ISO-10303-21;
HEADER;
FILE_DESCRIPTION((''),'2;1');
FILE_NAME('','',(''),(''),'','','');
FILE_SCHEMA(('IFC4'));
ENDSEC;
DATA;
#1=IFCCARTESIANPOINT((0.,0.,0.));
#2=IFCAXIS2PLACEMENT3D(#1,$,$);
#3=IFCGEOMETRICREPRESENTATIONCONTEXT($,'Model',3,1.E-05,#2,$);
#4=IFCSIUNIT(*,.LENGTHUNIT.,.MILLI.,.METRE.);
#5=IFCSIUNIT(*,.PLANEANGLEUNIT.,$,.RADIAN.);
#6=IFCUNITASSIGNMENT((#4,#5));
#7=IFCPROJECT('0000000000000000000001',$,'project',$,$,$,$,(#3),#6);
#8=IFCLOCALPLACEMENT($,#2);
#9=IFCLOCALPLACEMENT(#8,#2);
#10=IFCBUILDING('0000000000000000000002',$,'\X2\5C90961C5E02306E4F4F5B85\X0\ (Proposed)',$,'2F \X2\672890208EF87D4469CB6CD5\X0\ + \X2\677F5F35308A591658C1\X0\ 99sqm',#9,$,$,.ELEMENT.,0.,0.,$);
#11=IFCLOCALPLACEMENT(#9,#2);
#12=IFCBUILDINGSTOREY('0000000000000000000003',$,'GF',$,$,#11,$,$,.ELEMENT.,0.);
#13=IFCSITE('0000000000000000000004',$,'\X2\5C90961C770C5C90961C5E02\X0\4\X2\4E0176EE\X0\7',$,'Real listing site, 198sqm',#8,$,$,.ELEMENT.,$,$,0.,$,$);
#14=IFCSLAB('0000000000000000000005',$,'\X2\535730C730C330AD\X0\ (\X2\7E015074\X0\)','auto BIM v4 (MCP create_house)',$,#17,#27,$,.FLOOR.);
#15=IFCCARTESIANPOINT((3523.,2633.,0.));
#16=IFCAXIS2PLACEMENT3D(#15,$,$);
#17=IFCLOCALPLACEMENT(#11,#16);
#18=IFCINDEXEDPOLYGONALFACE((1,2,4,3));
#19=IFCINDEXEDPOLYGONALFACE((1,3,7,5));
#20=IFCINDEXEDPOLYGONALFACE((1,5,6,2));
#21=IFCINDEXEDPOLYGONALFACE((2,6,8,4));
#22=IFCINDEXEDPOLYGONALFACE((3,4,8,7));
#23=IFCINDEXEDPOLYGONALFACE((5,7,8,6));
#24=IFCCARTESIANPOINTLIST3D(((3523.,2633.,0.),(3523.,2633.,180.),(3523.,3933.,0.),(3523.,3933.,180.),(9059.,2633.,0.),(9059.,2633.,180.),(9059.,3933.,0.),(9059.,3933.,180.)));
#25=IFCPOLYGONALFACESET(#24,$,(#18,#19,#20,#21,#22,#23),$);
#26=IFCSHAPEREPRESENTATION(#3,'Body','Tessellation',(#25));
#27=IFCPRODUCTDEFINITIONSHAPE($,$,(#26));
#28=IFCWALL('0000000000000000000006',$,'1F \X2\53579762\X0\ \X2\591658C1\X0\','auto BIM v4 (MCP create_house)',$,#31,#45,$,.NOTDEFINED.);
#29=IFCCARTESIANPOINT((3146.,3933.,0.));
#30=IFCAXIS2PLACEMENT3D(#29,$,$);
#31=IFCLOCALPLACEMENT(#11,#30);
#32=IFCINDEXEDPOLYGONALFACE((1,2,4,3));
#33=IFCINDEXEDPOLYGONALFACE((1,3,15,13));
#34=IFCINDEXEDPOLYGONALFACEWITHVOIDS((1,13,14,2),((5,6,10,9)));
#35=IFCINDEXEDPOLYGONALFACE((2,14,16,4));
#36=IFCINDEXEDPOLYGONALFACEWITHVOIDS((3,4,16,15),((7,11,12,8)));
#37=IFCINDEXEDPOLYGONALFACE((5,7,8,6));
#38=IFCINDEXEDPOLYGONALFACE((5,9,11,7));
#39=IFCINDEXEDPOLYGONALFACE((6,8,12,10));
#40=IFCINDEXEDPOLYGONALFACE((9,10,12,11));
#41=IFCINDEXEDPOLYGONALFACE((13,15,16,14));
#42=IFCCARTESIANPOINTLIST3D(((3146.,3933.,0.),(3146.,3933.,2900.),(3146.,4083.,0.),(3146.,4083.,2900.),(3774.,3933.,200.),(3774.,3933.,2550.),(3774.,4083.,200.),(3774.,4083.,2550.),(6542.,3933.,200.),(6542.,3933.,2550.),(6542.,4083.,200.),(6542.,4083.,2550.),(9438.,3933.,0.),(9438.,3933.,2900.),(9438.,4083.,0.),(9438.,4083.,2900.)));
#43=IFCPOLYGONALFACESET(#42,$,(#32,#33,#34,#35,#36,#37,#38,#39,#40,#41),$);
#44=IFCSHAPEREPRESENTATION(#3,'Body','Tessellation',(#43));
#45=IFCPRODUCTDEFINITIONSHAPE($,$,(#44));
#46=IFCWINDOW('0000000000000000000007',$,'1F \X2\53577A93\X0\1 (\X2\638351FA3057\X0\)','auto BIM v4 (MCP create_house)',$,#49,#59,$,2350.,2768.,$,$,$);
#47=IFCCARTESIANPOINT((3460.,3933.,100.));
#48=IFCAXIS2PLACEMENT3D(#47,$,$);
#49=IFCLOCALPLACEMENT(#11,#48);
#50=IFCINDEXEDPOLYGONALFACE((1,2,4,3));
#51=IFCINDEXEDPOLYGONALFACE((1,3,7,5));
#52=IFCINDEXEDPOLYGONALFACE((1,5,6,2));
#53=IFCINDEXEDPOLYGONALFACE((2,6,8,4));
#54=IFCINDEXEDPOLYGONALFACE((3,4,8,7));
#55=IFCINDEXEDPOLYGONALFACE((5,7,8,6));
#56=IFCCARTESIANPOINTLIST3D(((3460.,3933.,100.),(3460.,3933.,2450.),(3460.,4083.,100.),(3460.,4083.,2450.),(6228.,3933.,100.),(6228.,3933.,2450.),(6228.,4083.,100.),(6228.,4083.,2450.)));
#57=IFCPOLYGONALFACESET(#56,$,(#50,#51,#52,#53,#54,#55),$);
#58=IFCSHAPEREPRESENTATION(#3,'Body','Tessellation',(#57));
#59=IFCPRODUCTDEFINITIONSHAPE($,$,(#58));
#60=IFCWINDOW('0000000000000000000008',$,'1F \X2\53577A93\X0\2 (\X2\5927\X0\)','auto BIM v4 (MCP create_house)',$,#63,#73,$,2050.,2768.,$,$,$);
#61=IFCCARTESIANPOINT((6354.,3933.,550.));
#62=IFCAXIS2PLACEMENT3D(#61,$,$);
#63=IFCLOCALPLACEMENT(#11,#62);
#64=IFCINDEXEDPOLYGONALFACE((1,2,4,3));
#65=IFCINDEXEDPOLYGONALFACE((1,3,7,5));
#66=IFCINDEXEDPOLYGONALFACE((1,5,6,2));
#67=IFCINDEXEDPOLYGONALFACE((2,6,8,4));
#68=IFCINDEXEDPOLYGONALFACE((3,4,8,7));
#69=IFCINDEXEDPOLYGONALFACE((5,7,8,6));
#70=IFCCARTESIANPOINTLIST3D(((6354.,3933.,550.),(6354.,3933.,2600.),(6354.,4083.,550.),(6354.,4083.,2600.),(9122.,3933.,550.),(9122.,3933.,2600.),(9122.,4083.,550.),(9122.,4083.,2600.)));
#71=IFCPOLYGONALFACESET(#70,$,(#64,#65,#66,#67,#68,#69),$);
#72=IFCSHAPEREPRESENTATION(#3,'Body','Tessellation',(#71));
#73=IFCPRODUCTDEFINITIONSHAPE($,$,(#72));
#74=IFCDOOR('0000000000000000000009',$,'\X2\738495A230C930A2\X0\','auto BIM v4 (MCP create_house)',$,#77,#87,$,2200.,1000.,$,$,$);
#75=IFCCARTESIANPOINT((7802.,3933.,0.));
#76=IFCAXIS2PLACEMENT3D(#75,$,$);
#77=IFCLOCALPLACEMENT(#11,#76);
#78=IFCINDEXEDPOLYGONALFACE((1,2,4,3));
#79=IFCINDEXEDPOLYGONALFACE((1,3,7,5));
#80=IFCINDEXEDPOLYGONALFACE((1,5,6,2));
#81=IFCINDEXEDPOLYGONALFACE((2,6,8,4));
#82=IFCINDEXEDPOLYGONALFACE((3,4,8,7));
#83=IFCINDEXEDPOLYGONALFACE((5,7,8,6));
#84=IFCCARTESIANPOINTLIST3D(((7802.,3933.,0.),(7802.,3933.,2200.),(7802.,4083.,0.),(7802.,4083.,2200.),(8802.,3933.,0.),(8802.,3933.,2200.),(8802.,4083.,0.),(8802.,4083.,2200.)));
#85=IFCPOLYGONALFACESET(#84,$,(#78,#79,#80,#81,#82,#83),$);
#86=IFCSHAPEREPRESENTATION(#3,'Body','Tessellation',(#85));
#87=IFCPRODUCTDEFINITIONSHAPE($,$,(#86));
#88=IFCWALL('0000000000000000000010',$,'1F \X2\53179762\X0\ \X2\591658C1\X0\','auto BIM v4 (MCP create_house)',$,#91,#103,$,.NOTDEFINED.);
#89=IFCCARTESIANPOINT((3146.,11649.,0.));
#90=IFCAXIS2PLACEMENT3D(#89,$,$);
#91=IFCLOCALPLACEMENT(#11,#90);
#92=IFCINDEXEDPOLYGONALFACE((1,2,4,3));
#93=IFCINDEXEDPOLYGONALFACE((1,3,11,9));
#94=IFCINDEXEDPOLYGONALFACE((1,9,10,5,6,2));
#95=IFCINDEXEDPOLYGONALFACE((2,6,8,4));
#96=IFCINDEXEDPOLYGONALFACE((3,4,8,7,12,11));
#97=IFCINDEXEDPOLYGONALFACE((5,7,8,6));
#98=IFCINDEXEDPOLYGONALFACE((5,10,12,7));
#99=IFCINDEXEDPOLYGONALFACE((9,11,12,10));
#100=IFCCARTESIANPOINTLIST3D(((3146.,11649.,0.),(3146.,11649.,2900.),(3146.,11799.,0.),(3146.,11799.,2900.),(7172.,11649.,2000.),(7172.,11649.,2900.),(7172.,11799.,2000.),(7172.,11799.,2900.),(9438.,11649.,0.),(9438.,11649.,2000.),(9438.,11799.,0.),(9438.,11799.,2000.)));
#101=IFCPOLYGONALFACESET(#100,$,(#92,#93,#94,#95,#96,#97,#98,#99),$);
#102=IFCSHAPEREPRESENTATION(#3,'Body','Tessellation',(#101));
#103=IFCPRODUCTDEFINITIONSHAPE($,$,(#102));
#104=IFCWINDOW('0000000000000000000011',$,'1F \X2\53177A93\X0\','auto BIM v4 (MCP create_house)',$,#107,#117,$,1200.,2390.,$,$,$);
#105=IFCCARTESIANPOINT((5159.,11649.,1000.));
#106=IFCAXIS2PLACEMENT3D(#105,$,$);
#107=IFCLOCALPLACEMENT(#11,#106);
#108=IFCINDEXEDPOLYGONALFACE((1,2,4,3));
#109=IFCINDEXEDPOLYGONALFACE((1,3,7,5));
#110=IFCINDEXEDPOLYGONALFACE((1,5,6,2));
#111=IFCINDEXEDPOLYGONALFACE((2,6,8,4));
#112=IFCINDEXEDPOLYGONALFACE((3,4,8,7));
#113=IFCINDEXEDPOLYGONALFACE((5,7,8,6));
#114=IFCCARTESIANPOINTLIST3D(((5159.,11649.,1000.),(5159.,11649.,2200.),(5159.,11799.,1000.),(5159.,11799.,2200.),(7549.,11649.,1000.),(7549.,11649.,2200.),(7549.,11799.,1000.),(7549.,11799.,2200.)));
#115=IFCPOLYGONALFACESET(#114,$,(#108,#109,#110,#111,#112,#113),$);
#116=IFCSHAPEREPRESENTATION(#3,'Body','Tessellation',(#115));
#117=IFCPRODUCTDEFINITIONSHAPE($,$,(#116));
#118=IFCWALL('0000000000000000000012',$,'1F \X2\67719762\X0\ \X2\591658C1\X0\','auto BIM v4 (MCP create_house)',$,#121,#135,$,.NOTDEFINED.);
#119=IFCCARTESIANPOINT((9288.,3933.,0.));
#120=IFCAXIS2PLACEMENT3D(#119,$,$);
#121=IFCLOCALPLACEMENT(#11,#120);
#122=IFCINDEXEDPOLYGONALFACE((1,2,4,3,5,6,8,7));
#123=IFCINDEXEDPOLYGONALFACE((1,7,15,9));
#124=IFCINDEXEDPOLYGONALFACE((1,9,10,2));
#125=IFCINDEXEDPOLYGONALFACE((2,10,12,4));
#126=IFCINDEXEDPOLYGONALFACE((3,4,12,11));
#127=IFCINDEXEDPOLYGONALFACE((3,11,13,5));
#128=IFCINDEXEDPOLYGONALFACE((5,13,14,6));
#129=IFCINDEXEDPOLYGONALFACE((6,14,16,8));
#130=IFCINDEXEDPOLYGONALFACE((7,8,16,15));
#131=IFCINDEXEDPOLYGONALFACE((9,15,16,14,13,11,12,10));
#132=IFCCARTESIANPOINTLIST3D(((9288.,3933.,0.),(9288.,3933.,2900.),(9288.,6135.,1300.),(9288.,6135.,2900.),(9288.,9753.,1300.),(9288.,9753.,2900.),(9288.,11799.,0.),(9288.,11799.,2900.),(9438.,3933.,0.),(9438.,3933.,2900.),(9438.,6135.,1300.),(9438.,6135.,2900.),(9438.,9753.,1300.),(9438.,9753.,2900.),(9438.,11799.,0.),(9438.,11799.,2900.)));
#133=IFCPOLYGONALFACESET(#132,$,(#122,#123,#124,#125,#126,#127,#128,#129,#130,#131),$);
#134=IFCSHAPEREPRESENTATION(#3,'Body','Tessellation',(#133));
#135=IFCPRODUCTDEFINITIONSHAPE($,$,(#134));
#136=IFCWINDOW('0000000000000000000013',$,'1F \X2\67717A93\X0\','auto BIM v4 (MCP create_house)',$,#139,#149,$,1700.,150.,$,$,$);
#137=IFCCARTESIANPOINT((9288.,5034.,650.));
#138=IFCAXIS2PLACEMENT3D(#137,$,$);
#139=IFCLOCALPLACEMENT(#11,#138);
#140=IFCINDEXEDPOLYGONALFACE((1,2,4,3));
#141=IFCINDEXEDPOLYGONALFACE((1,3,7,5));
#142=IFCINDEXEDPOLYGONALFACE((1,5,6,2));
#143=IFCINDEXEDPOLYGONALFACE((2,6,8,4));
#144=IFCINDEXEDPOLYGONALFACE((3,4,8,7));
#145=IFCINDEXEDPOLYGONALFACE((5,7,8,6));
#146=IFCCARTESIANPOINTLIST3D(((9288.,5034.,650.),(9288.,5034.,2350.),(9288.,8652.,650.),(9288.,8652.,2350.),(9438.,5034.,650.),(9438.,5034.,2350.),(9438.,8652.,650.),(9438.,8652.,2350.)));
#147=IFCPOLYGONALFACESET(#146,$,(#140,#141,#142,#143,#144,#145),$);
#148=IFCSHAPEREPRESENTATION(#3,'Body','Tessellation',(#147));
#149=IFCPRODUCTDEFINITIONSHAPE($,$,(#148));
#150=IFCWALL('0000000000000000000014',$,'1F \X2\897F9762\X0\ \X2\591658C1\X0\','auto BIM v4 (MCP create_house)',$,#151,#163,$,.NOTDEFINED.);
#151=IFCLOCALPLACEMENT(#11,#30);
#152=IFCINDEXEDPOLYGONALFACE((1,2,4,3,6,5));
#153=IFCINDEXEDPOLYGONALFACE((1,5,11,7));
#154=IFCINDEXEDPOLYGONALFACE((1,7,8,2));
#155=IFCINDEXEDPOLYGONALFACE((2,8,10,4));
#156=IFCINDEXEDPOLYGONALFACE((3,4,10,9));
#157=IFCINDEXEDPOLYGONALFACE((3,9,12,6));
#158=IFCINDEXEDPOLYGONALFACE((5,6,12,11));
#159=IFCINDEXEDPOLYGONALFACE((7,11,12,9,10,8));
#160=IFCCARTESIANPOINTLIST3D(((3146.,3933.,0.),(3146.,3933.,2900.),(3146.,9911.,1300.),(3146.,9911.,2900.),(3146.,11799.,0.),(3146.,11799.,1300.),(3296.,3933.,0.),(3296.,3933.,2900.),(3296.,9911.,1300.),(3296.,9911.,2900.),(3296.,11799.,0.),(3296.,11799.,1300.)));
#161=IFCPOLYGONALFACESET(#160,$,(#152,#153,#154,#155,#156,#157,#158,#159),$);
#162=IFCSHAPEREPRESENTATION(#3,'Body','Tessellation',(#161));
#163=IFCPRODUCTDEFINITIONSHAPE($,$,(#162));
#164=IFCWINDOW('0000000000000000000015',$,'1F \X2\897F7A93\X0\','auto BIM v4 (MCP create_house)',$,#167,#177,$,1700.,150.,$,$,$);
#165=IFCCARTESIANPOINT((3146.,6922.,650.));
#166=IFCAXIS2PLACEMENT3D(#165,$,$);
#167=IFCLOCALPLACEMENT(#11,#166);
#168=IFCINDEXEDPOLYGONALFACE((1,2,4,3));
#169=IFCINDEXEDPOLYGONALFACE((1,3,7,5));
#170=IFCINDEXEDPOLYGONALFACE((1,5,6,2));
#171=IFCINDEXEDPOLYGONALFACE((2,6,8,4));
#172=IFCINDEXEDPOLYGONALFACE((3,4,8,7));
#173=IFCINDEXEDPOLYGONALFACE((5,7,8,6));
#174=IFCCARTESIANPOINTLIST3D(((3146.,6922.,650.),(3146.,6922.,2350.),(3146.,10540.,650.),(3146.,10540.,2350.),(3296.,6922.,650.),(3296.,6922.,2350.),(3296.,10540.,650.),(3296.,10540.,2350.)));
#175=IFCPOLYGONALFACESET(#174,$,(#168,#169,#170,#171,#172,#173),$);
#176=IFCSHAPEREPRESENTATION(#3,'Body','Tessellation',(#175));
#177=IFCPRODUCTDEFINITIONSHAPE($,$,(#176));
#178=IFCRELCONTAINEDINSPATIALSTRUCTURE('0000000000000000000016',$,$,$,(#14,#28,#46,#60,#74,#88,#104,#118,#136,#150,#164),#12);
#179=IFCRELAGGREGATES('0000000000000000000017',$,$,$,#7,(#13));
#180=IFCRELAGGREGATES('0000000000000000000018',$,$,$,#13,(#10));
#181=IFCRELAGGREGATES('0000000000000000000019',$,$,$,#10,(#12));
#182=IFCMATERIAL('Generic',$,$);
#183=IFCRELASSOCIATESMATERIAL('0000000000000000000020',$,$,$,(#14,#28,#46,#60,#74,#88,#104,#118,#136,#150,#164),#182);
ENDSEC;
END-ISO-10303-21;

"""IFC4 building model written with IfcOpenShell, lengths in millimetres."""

from ifc_helpers import new_model, si_unit, frame, frame_2d, origin, place, context, project, spatial, rectangle, extrude, material, element, fill, save


model = new_model("IFC4")

# Units and contexts
model_context = context("Model", 3, precision=1e-05, world=origin())
ifc_project = project(units=[si_unit("LENGTHUNIT", "METRE", prefix="MILLI"), si_unit("PLANEANGLEUNIT", "RADIAN")], contexts=[model_context])

# Site, building, storey
site_placement = place(None, origin())
site = spatial("IfcSite", under=ifc_project, at=site_placement, Name="岐阜県岐阜市4丁目7", ObjectType="Real listing site, 198sqm", CompositionType="ELEMENT", RefElevation=0.0)
building_placement = place(site_placement, origin())
building = spatial("IfcBuilding", under=site, at=building_placement, Name="岐阜市の住宅 (Proposed)", ObjectType="2F 木造軸組構法 + 板張り外壁 99sqm", CompositionType="ELEMENT", ElevationOfRefHeight=0.0, ElevationOfTerrain=0.0)
storey_placement = place(building_placement, origin())
storey = spatial("IfcBuildingStorey", under=building, at=storey_placement, Name="GF", CompositionType="ELEMENT", Elevation=0.0)

# Slab
ifc_material = material(Name="Generic")
slab_1_placement = place(storey_placement, frame((3523.0, 2633.0, 0.0)))
element("IfcSlab", 1, at=slab_1_placement, inside=storey, material=ifc_material, Name="南デッキ (縁側)", Description="auto BIM v4 (MCP create_house)", PredefinedType="FLOOR", context=model_context, shape_type="SweptSolid", body=[
    extrude(rectangle(XDim=5536.0, YDim=1300.0, at=frame_2d((2768.0, 650.0))), frame((3523.0, 2633.0, 0.0)), (0.0, 0.0, 1.0), 180.0),
])

# Wall, openings, windows, door
wall_1_placement = place(storey_placement, frame((3146.0, 3933.0, 0.0)))
wall_1 = element("IfcWall", 2, at=wall_1_placement, inside=storey, material=ifc_material, Name="1F 南面 外壁", Description="auto BIM v4 (MCP create_house)", PredefinedType="NOTDEFINED", context=model_context, shape_type="SweptSolid", body=[
    extrude(rectangle(XDim=6292.0, YDim=150.0, at=frame_2d((3146.0, 75.0))), frame((3146.0, 3933.0, 0.0)), (0.0, 0.0, 1.0), 2900.0),
])
opening_1_placement = place(storey_placement, frame((3460.0, 3933.0, 100.0)))
opening_1 = element("IfcOpeningElement", 3, at=opening_1_placement, cuts=wall_1, PredefinedType="NOTDEFINED", context=model_context, shape_type="SweptSolid", body=[
    extrude(rectangle(XDim=2768.0, YDim=150.0, at=frame_2d((1384.0, 75.0))), frame((3460.0, 3933.0, 100.0)), (0.0, 0.0, 1.0), 2350.0),
])
opening_2_placement = place(storey_placement, frame((6354.0, 3933.0, 550.0)))
opening_2 = element("IfcOpeningElement", 4, at=opening_2_placement, cuts=wall_1, PredefinedType="NOTDEFINED", context=model_context, shape_type="SweptSolid", body=[
    extrude(rectangle(XDim=2768.0, YDim=150.0, at=frame_2d((1384.0, 75.0))), frame((6354.0, 3933.0, 550.0)), (0.0, 0.0, 1.0), 2050.0),
])
opening_3_placement = place(storey_placement, frame((7802.0, 3933.0, 0.0)))
opening_3 = element("IfcOpeningElement", 5, at=opening_3_placement, cuts=wall_1, PredefinedType="NOTDEFINED", context=model_context, shape_type="SweptSolid", body=[
    extrude(rectangle(XDim=1000.0, YDim=150.0, at=frame_2d((500.0, 75.0))), frame((7802.0, 3933.0, 0.0)), (0.0, 0.0, 1.0), 2200.0),
])
window_1_placement = place(storey_placement, frame((3460.0, 3933.0, 100.0)))
window_1 = element("IfcWindow", 6, at=window_1_placement, inside=storey, material=ifc_material, Name="1F 南窓1 (掃出し)", Description="auto BIM v4 (MCP create_house)", OverallHeight=2350.0, OverallWidth=2768.0, context=model_context, shape_type="SweptSolid", body=[
    extrude(rectangle(XDim=2768.0, YDim=150.0, at=frame_2d((1384.0, 75.0))), frame((3460.0, 3933.0, 100.0)), (0.0, 0.0, 1.0), 2350.0),
])
fill(opening_1, window_1)
window_2_placement = place(storey_placement, frame((6354.0, 3933.0, 550.0)))
window_2 = element("IfcWindow", 7, at=window_2_placement, inside=storey, material=ifc_material, Name="1F 南窓2 (大)", Description="auto BIM v4 (MCP create_house)", OverallHeight=2050.0, OverallWidth=2768.0, context=model_context, shape_type="SweptSolid", body=[
    extrude(rectangle(XDim=2768.0, YDim=150.0, at=frame_2d((1384.0, 75.0))), frame((6354.0, 3933.0, 550.0)), (0.0, 0.0, 1.0), 2050.0),
])
fill(opening_2, window_2)
door_1_placement = place(storey_placement, frame((7802.0, 3933.0, 0.0)))
door_1 = element("IfcDoor", 8, at=door_1_placement, inside=storey, material=ifc_material, Name="玄関ドア", Description="auto BIM v4 (MCP create_house)", OverallHeight=2200.0, OverallWidth=1000.0, context=model_context, shape_type="SweptSolid", body=[
    extrude(rectangle(XDim=1000.0, YDim=150.0, at=frame_2d((500.0, 75.0))), frame((7802.0, 3933.0, 0.0)), (0.0, 0.0, 1.0), 2200.0),
])
fill(opening_3, door_1)

# Walls, openings, windows
wall_2_placement = place(storey_placement, frame((3146.0, 11649.0, 0.0)))
wall_2 = element("IfcWall", 9, at=wall_2_placement, inside=storey, material=ifc_material, Name="1F 北面 外壁", Description="auto BIM v4 (MCP create_house)", PredefinedType="NOTDEFINED", context=model_context, shape_type="SweptSolid", body=[
    extrude(rectangle(XDim=6292.0, YDim=150.0, at=frame_2d((3146.0, 75.0))), frame((3146.0, 11649.0, 0.0)), (0.0, 0.0, 1.0), 2900.0),
])
opening_4_placement = place(storey_placement, frame((5159.0, 11649.0, 1000.0)))
opening_4 = element("IfcOpeningElement", 10, at=opening_4_placement, cuts=wall_2, PredefinedType="NOTDEFINED", context=model_context, shape_type="SweptSolid", body=[
    extrude(rectangle(XDim=2390.0, YDim=150.0, at=frame_2d((1195.0, 75.0))), frame((5159.0, 11649.0, 1000.0)), (0.0, 0.0, 1.0), 1200.0),
])
window_3_placement = place(storey_placement, frame((5159.0, 11649.0, 1000.0)))
window_3 = element("IfcWindow", 11, at=window_3_placement, inside=storey, material=ifc_material, Name="1F 北窓", Description="auto BIM v4 (MCP create_house)", OverallHeight=1200.0, OverallWidth=2390.0, context=model_context, shape_type="SweptSolid", body=[
    extrude(rectangle(XDim=2390.0, YDim=150.0, at=frame_2d((1195.0, 75.0))), frame((5159.0, 11649.0, 1000.0)), (0.0, 0.0, 1.0), 1200.0),
])
fill(opening_4, window_3)
wall_3_placement = place(storey_placement, frame((9288.0, 3933.0, 0.0)))
wall_3 = element("IfcWall", 12, at=wall_3_placement, inside=storey, material=ifc_material, Name="1F 東面 外壁", Description="auto BIM v4 (MCP create_house)", PredefinedType="NOTDEFINED", context=model_context, shape_type="SweptSolid", body=[
    extrude(rectangle(XDim=150.0, YDim=7866.0, at=frame_2d((75.0, 3933.0))), frame((9288.0, 3933.0, 0.0)), (0.0, 0.0, 1.0), 2900.0),
])
opening_5_placement = place(storey_placement, frame((9288.0, 5034.0, 650.0)))
opening_5 = element("IfcOpeningElement", 13, at=opening_5_placement, cuts=wall_3, PredefinedType="NOTDEFINED", context=model_context, shape_type="SweptSolid", body=[
    extrude(rectangle(XDim=150.0, YDim=3618.0, at=frame_2d((75.0, 1809.0))), frame((9288.0, 5034.0, 650.0)), (0.0, 0.0, 1.0), 1700.0),
])
window_4_placement = place(storey_placement, frame((9288.0, 5034.0, 650.0)))
window_4 = element("IfcWindow", 14, at=window_4_placement, inside=storey, material=ifc_material, Name="1F 東窓", Description="auto BIM v4 (MCP create_house)", OverallHeight=1700.0, OverallWidth=150.0, context=model_context, shape_type="SweptSolid", body=[
    extrude(rectangle(XDim=150.0, YDim=3618.0, at=frame_2d((75.0, 1809.0))), frame((9288.0, 5034.0, 650.0)), (0.0, 0.0, 1.0), 1700.0),
])
fill(opening_5, window_4)
wall_4_placement = place(storey_placement, frame((3146.0, 3933.0, 0.0)))
wall_4 = element("IfcWall", 15, at=wall_4_placement, inside=storey, material=ifc_material, Name="1F 西面 外壁", Description="auto BIM v4 (MCP create_house)", PredefinedType="NOTDEFINED", context=model_context, shape_type="SweptSolid", body=[
    extrude(rectangle(XDim=150.0, YDim=7866.0, at=frame_2d((75.0, 3933.0))), frame((3146.0, 3933.0, 0.0)), (0.0, 0.0, 1.0), 2900.0),
])
opening_6_placement = place(storey_placement, frame((3146.0, 6922.0, 650.0)))
opening_6 = element("IfcOpeningElement", 16, at=opening_6_placement, cuts=wall_4, PredefinedType="NOTDEFINED", context=model_context, shape_type="SweptSolid", body=[
    extrude(rectangle(XDim=150.0, YDim=3618.0, at=frame_2d((75.0, 1809.0))), frame((3146.0, 6922.0, 650.0)), (0.0, 0.0, 1.0), 1700.0),
])
window_5_placement = place(storey_placement, frame((3146.0, 6922.0, 650.0)))
window_5 = element("IfcWindow", 17, at=window_5_placement, inside=storey, material=ifc_material, Name="1F 西窓", Description="auto BIM v4 (MCP create_house)", OverallHeight=1700.0, OverallWidth=150.0, context=model_context, shape_type="SweptSolid", body=[
    extrude(rectangle(XDim=150.0, YDim=3618.0, at=frame_2d((75.0, 1809.0))), frame((3146.0, 6922.0, 650.0)), (0.0, 0.0, 1.0), 1700.0),
])
fill(opening_6, window_5)

save(model, "model.ifc")
